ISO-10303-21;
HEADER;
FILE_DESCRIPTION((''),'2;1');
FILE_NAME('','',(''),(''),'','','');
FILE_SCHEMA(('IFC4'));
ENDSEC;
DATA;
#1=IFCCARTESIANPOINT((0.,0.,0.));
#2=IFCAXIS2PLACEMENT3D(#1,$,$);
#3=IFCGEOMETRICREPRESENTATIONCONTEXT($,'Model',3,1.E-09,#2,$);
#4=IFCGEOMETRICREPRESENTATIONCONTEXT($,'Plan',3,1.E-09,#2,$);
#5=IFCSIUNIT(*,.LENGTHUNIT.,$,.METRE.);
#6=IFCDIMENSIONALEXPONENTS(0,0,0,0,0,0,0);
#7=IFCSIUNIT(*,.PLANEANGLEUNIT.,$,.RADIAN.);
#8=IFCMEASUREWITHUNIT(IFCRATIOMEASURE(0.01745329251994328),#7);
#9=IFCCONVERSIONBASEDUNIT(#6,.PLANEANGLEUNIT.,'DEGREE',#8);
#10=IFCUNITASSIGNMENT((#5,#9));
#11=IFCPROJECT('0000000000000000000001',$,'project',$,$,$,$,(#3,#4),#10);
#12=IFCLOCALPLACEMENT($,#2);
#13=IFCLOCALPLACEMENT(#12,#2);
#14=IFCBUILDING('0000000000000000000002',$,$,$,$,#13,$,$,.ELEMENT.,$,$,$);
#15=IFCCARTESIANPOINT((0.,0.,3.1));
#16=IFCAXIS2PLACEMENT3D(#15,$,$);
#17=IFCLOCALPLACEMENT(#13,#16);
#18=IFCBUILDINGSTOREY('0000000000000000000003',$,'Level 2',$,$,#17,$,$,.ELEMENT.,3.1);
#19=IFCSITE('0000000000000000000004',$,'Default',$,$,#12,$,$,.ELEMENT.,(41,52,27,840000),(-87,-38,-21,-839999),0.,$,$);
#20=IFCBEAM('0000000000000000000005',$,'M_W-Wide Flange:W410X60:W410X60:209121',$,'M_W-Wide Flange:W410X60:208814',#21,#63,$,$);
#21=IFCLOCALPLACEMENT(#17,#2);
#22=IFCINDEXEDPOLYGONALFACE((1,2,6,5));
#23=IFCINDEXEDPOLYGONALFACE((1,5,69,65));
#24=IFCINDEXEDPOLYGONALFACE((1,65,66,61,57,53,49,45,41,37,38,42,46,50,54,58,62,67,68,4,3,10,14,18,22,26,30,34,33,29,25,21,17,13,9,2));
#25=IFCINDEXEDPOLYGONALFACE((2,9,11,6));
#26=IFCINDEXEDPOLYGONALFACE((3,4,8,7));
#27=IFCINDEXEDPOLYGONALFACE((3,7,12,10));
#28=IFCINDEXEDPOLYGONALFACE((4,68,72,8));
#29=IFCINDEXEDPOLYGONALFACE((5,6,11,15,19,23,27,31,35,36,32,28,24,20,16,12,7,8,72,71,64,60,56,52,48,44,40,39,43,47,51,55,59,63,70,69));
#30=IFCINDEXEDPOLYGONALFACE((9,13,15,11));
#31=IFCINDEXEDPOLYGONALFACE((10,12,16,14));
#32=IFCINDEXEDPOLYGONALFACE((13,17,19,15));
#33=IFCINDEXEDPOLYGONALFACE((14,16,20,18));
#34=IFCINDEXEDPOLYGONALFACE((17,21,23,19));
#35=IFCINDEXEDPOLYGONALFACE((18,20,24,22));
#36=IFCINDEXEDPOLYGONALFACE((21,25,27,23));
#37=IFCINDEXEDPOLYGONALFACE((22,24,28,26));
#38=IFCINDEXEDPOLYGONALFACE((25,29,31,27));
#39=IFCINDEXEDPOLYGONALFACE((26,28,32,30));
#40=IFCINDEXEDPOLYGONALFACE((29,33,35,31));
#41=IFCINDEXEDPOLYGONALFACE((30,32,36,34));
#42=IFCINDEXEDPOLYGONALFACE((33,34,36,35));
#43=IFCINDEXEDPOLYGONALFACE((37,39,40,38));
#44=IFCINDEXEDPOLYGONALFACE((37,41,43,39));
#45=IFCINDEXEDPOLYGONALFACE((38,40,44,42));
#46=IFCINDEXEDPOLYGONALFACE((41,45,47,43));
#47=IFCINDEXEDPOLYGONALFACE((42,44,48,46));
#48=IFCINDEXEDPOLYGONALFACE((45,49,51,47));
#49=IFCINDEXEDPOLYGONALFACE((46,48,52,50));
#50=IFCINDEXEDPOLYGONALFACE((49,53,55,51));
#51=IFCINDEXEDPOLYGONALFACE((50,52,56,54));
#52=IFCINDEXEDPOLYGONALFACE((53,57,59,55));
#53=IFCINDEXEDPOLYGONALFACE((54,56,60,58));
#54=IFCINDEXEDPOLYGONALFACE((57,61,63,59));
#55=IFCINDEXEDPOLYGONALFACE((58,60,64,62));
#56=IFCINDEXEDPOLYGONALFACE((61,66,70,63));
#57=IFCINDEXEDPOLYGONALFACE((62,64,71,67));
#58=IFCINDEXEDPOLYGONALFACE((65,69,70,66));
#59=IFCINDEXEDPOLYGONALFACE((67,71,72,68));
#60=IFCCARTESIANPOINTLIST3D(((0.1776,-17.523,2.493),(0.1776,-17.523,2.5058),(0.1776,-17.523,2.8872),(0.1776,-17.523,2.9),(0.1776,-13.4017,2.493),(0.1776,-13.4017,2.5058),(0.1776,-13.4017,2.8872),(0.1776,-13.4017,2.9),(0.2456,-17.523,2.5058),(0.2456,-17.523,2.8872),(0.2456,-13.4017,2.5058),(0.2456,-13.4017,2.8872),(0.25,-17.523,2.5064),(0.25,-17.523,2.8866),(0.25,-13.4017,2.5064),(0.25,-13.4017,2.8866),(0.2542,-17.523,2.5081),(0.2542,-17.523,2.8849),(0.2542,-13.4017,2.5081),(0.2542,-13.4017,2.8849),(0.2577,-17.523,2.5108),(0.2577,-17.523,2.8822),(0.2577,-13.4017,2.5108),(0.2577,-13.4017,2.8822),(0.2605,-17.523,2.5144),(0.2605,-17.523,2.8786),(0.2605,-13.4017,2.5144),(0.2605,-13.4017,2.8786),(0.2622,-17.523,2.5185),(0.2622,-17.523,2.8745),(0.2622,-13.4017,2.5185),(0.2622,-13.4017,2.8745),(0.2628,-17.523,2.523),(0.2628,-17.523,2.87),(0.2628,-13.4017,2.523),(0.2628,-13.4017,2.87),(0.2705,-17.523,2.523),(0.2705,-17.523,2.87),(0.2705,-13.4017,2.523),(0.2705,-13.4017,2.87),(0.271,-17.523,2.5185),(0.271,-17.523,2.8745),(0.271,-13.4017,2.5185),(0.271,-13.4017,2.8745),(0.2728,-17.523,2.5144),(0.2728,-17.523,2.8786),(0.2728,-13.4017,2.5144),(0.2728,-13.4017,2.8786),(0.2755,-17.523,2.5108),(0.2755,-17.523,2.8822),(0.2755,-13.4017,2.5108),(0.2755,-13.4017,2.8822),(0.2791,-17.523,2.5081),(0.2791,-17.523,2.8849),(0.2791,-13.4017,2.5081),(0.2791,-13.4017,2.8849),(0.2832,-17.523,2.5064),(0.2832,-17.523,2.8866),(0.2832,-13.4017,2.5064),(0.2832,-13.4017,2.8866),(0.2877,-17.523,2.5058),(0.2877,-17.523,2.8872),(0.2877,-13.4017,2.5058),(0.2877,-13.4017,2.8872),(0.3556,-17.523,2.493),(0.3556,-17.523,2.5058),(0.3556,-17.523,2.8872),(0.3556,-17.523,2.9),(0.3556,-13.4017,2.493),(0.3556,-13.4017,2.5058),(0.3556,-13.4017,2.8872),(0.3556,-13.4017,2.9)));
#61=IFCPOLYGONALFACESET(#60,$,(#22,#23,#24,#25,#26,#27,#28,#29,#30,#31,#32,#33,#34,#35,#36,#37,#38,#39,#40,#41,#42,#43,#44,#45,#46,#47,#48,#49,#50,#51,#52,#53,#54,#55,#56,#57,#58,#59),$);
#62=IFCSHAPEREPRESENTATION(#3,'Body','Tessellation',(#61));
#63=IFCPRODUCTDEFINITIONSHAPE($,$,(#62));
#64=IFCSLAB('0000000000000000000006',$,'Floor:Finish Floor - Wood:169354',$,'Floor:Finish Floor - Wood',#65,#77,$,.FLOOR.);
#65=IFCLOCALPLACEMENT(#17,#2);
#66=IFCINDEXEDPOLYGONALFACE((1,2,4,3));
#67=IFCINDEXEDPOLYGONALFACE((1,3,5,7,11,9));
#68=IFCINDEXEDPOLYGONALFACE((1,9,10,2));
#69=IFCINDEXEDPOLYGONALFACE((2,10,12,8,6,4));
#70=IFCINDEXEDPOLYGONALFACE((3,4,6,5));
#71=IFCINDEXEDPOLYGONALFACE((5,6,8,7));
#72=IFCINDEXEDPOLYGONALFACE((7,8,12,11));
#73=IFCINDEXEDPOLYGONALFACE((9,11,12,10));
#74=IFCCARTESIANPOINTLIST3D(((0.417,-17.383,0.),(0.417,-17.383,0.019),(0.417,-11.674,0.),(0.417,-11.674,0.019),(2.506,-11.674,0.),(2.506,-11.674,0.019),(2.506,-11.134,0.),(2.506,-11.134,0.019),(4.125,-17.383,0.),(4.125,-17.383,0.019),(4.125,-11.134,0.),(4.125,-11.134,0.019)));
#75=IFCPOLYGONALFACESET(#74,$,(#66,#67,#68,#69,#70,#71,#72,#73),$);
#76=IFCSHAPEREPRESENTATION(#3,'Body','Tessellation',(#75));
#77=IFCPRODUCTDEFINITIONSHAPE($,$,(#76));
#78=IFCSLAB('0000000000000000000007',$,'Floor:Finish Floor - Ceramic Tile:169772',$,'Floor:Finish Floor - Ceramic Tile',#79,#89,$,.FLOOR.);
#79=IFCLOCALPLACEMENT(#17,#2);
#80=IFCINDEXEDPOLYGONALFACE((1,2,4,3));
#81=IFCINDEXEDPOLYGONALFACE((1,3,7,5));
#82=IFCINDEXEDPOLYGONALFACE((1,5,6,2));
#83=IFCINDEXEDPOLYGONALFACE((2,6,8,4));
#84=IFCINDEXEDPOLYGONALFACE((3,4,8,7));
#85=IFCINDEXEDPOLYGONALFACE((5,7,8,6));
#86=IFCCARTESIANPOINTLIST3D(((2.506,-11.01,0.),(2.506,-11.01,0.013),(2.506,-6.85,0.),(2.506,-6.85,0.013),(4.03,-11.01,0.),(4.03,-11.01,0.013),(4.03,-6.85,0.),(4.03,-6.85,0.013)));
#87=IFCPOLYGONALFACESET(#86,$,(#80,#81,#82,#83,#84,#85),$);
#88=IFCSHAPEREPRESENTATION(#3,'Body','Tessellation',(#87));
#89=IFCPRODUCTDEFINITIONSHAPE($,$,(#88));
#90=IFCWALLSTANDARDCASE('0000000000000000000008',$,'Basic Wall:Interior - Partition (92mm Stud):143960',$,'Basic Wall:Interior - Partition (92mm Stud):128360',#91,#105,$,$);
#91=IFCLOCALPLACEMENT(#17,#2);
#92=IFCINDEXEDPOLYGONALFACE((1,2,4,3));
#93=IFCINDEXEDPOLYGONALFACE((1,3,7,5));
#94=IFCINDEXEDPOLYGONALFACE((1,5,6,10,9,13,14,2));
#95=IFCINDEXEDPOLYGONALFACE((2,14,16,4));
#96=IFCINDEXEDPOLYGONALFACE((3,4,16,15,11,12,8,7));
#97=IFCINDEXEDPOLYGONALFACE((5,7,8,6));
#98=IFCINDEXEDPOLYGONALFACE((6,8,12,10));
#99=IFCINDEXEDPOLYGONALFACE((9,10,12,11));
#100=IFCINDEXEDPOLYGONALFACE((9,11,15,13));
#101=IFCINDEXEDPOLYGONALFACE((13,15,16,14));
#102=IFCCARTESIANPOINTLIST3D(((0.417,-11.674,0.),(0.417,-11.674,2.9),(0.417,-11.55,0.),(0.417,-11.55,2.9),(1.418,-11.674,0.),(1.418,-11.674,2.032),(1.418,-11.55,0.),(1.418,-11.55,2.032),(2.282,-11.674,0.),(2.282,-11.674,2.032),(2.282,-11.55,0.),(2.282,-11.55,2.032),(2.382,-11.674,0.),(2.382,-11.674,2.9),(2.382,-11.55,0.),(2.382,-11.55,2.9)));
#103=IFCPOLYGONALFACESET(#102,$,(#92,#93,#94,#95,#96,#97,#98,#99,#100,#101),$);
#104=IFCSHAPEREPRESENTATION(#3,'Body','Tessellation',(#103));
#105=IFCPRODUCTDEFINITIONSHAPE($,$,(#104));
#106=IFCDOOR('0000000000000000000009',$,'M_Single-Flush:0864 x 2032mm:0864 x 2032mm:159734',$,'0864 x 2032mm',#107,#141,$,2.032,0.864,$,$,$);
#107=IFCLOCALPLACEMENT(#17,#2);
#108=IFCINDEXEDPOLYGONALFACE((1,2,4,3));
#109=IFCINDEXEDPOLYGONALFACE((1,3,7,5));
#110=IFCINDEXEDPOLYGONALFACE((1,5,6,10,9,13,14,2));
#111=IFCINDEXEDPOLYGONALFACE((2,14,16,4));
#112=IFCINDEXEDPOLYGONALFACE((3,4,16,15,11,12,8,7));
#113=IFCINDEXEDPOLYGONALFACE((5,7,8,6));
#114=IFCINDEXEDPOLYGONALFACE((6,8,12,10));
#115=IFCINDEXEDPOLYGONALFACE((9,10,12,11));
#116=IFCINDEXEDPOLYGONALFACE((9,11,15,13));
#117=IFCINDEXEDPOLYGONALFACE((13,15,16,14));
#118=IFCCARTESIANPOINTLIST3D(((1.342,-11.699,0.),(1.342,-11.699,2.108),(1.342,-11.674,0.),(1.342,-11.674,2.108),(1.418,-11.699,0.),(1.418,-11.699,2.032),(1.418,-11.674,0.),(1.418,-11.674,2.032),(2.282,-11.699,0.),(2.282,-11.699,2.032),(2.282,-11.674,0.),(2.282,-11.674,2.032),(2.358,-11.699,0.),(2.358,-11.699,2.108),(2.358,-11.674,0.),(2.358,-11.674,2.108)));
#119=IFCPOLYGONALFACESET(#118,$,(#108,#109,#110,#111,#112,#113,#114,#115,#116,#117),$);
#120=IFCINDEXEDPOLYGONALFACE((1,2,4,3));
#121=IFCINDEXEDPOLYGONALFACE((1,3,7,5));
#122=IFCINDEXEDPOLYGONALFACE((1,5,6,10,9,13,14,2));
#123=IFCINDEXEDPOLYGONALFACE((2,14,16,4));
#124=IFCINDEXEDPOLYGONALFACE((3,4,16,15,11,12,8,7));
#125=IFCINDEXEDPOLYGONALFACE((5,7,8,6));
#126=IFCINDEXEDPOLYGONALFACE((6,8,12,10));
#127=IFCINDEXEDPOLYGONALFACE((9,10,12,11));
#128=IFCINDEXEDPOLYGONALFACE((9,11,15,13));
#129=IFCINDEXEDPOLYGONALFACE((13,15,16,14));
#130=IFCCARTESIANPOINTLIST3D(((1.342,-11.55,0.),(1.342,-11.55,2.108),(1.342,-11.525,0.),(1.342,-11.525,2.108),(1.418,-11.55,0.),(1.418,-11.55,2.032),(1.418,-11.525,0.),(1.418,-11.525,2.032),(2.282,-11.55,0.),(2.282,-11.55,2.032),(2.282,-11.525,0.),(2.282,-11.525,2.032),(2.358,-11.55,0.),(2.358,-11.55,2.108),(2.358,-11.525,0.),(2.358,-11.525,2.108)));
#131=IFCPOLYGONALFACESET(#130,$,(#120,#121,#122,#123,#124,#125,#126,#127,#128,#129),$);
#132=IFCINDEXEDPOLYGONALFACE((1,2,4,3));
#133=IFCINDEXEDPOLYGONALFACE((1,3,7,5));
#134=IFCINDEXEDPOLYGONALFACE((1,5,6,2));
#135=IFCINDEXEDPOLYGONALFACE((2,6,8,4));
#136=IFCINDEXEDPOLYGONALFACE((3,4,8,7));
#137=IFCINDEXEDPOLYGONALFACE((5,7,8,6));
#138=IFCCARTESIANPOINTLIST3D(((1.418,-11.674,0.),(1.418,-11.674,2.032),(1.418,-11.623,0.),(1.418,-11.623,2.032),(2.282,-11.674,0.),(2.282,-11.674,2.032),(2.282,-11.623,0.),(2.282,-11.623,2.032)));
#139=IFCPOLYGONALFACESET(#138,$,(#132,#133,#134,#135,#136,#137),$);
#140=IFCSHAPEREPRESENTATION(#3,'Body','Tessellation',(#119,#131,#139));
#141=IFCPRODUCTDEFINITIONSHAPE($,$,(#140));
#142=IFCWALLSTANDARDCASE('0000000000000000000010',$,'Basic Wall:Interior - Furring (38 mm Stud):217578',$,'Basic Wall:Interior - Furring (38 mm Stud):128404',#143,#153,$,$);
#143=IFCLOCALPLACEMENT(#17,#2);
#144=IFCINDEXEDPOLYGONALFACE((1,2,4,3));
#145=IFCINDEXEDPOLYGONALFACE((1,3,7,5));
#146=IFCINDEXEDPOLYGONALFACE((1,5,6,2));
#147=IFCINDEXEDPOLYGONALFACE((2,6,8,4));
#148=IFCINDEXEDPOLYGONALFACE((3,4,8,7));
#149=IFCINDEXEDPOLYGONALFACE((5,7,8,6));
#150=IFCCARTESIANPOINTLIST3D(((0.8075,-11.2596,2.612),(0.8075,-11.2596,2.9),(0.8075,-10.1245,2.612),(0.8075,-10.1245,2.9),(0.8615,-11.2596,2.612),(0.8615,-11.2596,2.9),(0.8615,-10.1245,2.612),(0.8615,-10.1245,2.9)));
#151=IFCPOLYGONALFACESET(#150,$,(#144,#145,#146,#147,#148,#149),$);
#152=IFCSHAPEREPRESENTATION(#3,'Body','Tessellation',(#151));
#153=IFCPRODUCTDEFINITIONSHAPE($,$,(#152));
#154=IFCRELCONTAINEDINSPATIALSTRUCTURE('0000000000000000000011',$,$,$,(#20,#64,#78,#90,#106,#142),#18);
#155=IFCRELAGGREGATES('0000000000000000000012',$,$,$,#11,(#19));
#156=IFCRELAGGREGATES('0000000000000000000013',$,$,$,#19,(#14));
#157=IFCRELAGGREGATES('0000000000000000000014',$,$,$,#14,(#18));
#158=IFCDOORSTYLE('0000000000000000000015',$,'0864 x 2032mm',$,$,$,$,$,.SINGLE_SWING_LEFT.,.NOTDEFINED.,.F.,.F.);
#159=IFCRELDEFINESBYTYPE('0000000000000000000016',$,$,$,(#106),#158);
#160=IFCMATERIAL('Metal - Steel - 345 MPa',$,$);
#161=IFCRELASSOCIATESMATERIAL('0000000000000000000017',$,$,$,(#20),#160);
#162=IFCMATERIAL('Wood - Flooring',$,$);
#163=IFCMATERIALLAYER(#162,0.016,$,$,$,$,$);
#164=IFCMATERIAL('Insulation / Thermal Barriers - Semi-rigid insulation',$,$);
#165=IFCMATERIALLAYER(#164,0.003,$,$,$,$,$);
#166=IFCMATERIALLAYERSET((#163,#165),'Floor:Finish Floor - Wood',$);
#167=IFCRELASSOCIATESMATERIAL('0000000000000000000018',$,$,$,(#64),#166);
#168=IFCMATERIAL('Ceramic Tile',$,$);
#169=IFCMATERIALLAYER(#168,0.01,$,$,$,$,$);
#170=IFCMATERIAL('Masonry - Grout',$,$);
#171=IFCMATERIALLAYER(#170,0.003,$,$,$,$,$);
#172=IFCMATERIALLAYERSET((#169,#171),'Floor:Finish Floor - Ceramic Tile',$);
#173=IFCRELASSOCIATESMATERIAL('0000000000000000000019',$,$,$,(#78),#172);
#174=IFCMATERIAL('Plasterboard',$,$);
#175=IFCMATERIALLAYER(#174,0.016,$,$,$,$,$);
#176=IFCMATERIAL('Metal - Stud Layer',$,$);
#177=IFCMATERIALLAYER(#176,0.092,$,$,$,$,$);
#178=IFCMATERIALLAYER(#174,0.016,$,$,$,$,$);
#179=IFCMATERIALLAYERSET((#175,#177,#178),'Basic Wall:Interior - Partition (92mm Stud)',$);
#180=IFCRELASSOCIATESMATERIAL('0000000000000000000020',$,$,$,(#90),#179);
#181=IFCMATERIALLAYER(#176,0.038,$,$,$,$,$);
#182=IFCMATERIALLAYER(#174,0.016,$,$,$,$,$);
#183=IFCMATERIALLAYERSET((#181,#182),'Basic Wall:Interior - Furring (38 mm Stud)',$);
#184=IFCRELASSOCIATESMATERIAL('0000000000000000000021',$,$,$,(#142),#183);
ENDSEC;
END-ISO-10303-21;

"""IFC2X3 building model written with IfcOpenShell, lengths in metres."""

from ifc_helpers import new_model, entity, si_unit, converted_unit, frame, frame_2d, origin, origin_2d_with_axis, place, context, project, spatial, polyline, circle_curve, parameter, trimmed, segment, composite_curve, rectangle, outline, extrude, source, transform, mapped, material, layer, layer_set, layer_usage, type_object, type_shapes, element, fill, save


model = new_model("IFC2X3")

# Units and contexts
model_context = context("Model", 3, precision=1e-09, world=origin())
plan_context = context("Plan", 3, precision=1e-09, world=origin())
ifc_project = project(units=[si_unit("LENGTHUNIT", "METRE"), converted_unit("PLANEANGLEUNIT", "DEGREE", entity("IfcRatioMeasure", 0.01745329251994328), si_unit("PLANEANGLEUNIT", "RADIAN"), dimensions=[0, 0, 0, 0, 0, 0, 0])], contexts=[model_context, plan_context])

# Site, building, storey
site_placement = place(None, origin())
site = spatial("IfcSite", under=ifc_project, at=site_placement, Name="Default", CompositionType="ELEMENT", RefLatitude=(41, 52, 27, 840000), RefLongitude=(-87, -38, -21, -839999), RefElevation=0.0)
building_placement = place(site_placement, origin())
building = spatial("IfcBuilding", under=site, at=building_placement, CompositionType="ELEMENT")
storey_placement = place(building_placement, frame((0.0, 0.0, 3.1)))
storey = spatial("IfcBuildingStorey", under=building, at=storey_placement, Name="Level 2", CompositionType="ELEMENT", Elevation=3.1)

# Beam
ifc_material_1 = material(Name="Metal - Steel - 345 MPa")
beam_placement = place(storey_placement, frame((0.2666, -13.4017, 2.9), z_axis=(0.0, 0.0, 1.0), x_axis=(-1.0, 0.0, 0.0)))
element("IfcBeam", 1, at=beam_placement, inside=storey, material=ifc_material_1, Name="M_W-Wide Flange:W410X60:W410X60:209121", ObjectType="M_W-Wide Flange:W410X60:208814", context=model_context, shape_type="SweptSolid", body=[
    extrude(outline(composite_curve([segment(polyline([(0.1907, -0.089), (0.2035, -0.089)]), True, "CONTINUOUS"), segment(polyline([(0.2035, -0.089), (0.2035, 0.089)]), True, "CONTINUOUS"), segment(polyline([(0.2035, 0.089), (0.1907, 0.089)]), True, "CONTINUOUS"), segment(polyline([(0.1907, 0.089), (0.1907, 0.021)]), True, "CONTINUOUS"), segment(trimmed(circle_curve(frame_2d((0.1735, 0.021), x_axis=(1.0, 0.0)), 0.0172), [parameter(270.0)], [parameter(360.0)], True, "PARAMETER"), False, "CONTINUOUS"), segment(polyline([(0.1735, 0.0038), (-0.1735, 0.0038)]), True, "CONTINUOUS"), segment(trimmed(circle_curve(frame_2d((-0.1735, 0.021), x_axis=(0.0, -1.0)), 0.0172), [parameter(270.0)], [parameter(360.0)], True, "PARAMETER"), False, "CONTINUOUS"), segment(polyline([(-0.1907, 0.021), (-0.1907, 0.089)]), True, "CONTINUOUS"), segment(polyline([(-0.1907, 0.089), (-0.2035, 0.089)]), True, "CONTINUOUS"), segment(polyline([(-0.2035, 0.089), (-0.2035, -0.089)]), True, "CONTINUOUS"), segment(polyline([(-0.2035, -0.089), (-0.1907, -0.089)]), True, "CONTINUOUS"), segment(polyline([(-0.1907, -0.089), (-0.1907, -0.0211)]), True, "CONTINUOUS"), segment(trimmed(circle_curve(frame_2d((-0.1735, -0.0211), x_axis=(-1.0, 0.0)), 0.0172), [parameter(270.0)], [parameter(0.0)], True, "PARAMETER"), False, "CONTINUOUS"), segment(polyline([(-0.1735, -0.0039), (0.1735, -0.0039)]), True, "CONTINUOUS"), segment(trimmed(circle_curve(frame_2d((0.1735, -0.0211), x_axis=(0.0, 1.0)), 0.0172), [parameter(270.0)], [parameter(0.0)], True, "PARAMETER"), False, "CONTINUOUS"), segment(polyline([(0.1907, -0.0211), (0.1907, -0.089)]), True, "CONTINUOUS")], self_intersect=False)), frame((0.0, 4.1213, -0.2035), z_axis=(0.0, -1.0, 0.0), x_axis=(0.0, 0.0, -1.0)), (0.0, 0.0, 1.0), 4.1213),
])

# Slabs
ifc_material_2 = material(Name="Wood - Flooring")
ifc_layer_1 = layer(ifc_material_2, 0.016)
ifc_material_3 = material(Name="Insulation / Thermal Barriers - Semi-rigid insulation")
ifc_layer_2 = layer(ifc_material_3, 0.003)
ifc_layer_set_1 = layer_set([ifc_layer_1, ifc_layer_2], Name="Floor:Finish Floor - Wood")
ifc_layer_usage_1 = layer_usage(ifc_layer_set_1, "AXIS3", "POSITIVE", 0.0)
slab_1_placement = place(storey_placement, frame((0.417, -17.383, 0.0)))
element("IfcSlab", 2, at=slab_1_placement, inside=storey, material=ifc_layer_usage_1, Name="Floor:Finish Floor - Wood:169354", ObjectType="Floor:Finish Floor - Wood", PredefinedType="FLOOR", context=model_context, shape_type="SweptSolid", body=[
    extrude(outline(polyline([(-1.854, -3.1245), (1.854, -3.1245), (1.854, 2.5845), (-0.235, 2.5845), (-0.235, 3.1245), (-1.854, 3.1245), (-1.854, -3.1245)])), frame((1.854, 3.1245, 0.019), z_axis=(0.0, 0.0, -1.0), x_axis=(-1.0, 0.0, 0.0)), (0.0, 0.0, 1.0), 0.019),
])
ifc_material_4 = material(Name="Ceramic Tile")
ifc_layer_3 = layer(ifc_material_4, 0.01)
ifc_material_5 = material(Name="Masonry - Grout")
ifc_layer_4 = layer(ifc_material_5, 0.003)
ifc_layer_set_2 = layer_set([ifc_layer_3, ifc_layer_4], Name="Floor:Finish Floor - Ceramic Tile")
ifc_layer_usage_2 = layer_usage(ifc_layer_set_2, "AXIS3", "POSITIVE", 0.0)
slab_2_placement = place(storey_placement, frame((2.506, -11.01, 0.0)))
element("IfcSlab", 3, at=slab_2_placement, inside=storey, material=ifc_layer_usage_2, Name="Floor:Finish Floor - Ceramic Tile:169772", ObjectType="Floor:Finish Floor - Ceramic Tile", PredefinedType="FLOOR", context=model_context, shape_type="SweptSolid", body=[
    extrude(rectangle(XDim=4.16, YDim=1.524, at=frame_2d((0.0, 0.0), x_axis=(0.0, -1.0))), frame((0.762, 2.08, 0.013), z_axis=(0.0, 0.0, -1.0), x_axis=(-1.0, 0.0, 0.0)), (0.0, 0.0, 1.0), 0.013),
])

# Shared definitions
ifc_material_6 = material(Name="Metal - Stud Layer")
ifc_material_7 = material(Name="Plasterboard")

# Wall, opening, door
ifc_layer_5 = layer(ifc_material_7, 0.016)
ifc_layer_6 = layer(ifc_material_6, 0.092)
ifc_layer_7 = layer(ifc_material_7, 0.016)
ifc_layer_set_3 = layer_set([ifc_layer_5, ifc_layer_6, ifc_layer_7], Name="Basic Wall:Interior - Partition (92mm Stud)")
ifc_layer_usage_3 = layer_usage(ifc_layer_set_3, "AXIS2", "NEGATIVE", 0.062)
wall_1_placement = place(storey_placement, frame((2.382, -11.612, 0.0), z_axis=(0.0, 0.0, 1.0), x_axis=(-1.0, 0.0, 0.0)))
wall_1 = element("IfcWallStandardCase", 4, at=wall_1_placement, inside=storey, material=ifc_layer_usage_3, Name="Basic Wall:Interior - Partition (92mm Stud):143960", ObjectType="Basic Wall:Interior - Partition (92mm Stud):128360", context=model_context, shape_type="SweptSolid", body=[
    extrude(rectangle(XDim=1.965, YDim=0.124, at=frame_2d((0.9825, 0.0), x_axis=(-1.0, 0.0))), origin(), (0.0, 0.0, 1.0), 2.9),
])
opening_1_placement = place(wall_1_placement, frame((0.1, -0.062, 0.0)))
opening_1 = element("IfcOpeningElement", 5, at=opening_1_placement, cuts=wall_1, ObjectType="Opening", context=model_context, shape_type="SweptSolid", body=[
    extrude(rectangle(XDim=0.864, YDim=2.032, at=frame_2d((1.016, 0.432), x_axis=(0.0, -1.0))), frame((0.0, 0.0, 0.0), z_axis=(0.0, 1.0, 0.0), x_axis=(0.0, 0.0, 1.0)), (0.0, 0.0, 1.0), 0.124),
])
door_style = type_object("IfcDoorStyle", Name="0864 x 2032mm", ConstructionType="NOTDEFINED", OperationType="SINGLE_SWING_LEFT", ParameterTakesPrecedence=False, Sizeable=False)
shared_shape_1 = source(origin(), model_context, "Body", "SweptSolid", [
    extrude(outline(polyline([(-0.508, -1.073), (0.508, -1.073), (0.508, 1.035), (0.432, 1.035), (0.432, -0.997), (-0.432, -0.997), (-0.432, 1.035), (-0.508, 1.035), (-0.508, -1.073)])), frame((0.432, 0.149, 1.035), z_axis=(0.0, -1.0, 0.0), x_axis=(-1.0, 0.0, 0.0)), (0.0, 0.0, 1.0), 0.025),
    extrude(outline(polyline([(-1.073, -0.508), (1.035, -0.508), (1.035, -0.432), (-0.997, -0.432), (-0.997, 0.432), (1.035, 0.432), (1.035, 0.508), (-1.073, 0.508), (-1.073, -0.508)])), frame((0.432, 0.0, 1.035), z_axis=(0.0, -1.0, 0.0), x_axis=(0.0, 0.0, -1.0)), (0.0, 0.0, 1.0), 0.025),
    extrude(rectangle(XDim=0.864, YDim=0.051, at=origin_2d_with_axis()), frame((0.432, 0.0985, 0.0)), (0.0, 0.0, 1.0), 2.032),
])
type_shapes(door_style, [shared_shape_1])
door_placement = place(opening_1_placement, origin())
door = element("IfcDoor", 6, at=door_placement, inside=storey, type_object=door_style, Name="M_Single-Flush:0864 x 2032mm:0864 x 2032mm:159734", ObjectType="0864 x 2032mm", OverallHeight=2.032, OverallWidth=0.864, context=model_context, shape_type="MappedRepresentation", body=[
    mapped(shared_shape_1, transform((0.0, 0.0, 0.0), scale=1.0)),
])
fill(opening_1, door)

# Wall
ifc_layer_8 = layer(ifc_material_6, 0.038)
ifc_layer_9 = layer(ifc_material_7, 0.016)
ifc_layer_set_4 = layer_set([ifc_layer_8, ifc_layer_9], Name="Basic Wall:Interior - Furring (38 mm Stud)")
ifc_layer_usage_4 = layer_usage(ifc_layer_set_4, "AXIS2", "NEGATIVE", 0.027)
wall_2_placement = place(storey_placement, frame((0.8345, -11.2596, 2.612), z_axis=(0.0, 0.0, 1.0), x_axis=(0.0, 1.0, 0.0)))
element("IfcWallStandardCase", 7, at=wall_2_placement, inside=storey, material=ifc_layer_usage_4, Name="Basic Wall:Interior - Furring (38 mm Stud):217578", ObjectType="Basic Wall:Interior - Furring (38 mm Stud):128404", context=model_context, shape_type="SweptSolid", body=[
    extrude(rectangle(XDim=1.1351, YDim=0.054, at=frame_2d((0.5675, 0.0), x_axis=(-1.0, 0.0))), origin(), (0.0, 0.0, 1.0), 0.288),
])

save(model, "model.ifc")
